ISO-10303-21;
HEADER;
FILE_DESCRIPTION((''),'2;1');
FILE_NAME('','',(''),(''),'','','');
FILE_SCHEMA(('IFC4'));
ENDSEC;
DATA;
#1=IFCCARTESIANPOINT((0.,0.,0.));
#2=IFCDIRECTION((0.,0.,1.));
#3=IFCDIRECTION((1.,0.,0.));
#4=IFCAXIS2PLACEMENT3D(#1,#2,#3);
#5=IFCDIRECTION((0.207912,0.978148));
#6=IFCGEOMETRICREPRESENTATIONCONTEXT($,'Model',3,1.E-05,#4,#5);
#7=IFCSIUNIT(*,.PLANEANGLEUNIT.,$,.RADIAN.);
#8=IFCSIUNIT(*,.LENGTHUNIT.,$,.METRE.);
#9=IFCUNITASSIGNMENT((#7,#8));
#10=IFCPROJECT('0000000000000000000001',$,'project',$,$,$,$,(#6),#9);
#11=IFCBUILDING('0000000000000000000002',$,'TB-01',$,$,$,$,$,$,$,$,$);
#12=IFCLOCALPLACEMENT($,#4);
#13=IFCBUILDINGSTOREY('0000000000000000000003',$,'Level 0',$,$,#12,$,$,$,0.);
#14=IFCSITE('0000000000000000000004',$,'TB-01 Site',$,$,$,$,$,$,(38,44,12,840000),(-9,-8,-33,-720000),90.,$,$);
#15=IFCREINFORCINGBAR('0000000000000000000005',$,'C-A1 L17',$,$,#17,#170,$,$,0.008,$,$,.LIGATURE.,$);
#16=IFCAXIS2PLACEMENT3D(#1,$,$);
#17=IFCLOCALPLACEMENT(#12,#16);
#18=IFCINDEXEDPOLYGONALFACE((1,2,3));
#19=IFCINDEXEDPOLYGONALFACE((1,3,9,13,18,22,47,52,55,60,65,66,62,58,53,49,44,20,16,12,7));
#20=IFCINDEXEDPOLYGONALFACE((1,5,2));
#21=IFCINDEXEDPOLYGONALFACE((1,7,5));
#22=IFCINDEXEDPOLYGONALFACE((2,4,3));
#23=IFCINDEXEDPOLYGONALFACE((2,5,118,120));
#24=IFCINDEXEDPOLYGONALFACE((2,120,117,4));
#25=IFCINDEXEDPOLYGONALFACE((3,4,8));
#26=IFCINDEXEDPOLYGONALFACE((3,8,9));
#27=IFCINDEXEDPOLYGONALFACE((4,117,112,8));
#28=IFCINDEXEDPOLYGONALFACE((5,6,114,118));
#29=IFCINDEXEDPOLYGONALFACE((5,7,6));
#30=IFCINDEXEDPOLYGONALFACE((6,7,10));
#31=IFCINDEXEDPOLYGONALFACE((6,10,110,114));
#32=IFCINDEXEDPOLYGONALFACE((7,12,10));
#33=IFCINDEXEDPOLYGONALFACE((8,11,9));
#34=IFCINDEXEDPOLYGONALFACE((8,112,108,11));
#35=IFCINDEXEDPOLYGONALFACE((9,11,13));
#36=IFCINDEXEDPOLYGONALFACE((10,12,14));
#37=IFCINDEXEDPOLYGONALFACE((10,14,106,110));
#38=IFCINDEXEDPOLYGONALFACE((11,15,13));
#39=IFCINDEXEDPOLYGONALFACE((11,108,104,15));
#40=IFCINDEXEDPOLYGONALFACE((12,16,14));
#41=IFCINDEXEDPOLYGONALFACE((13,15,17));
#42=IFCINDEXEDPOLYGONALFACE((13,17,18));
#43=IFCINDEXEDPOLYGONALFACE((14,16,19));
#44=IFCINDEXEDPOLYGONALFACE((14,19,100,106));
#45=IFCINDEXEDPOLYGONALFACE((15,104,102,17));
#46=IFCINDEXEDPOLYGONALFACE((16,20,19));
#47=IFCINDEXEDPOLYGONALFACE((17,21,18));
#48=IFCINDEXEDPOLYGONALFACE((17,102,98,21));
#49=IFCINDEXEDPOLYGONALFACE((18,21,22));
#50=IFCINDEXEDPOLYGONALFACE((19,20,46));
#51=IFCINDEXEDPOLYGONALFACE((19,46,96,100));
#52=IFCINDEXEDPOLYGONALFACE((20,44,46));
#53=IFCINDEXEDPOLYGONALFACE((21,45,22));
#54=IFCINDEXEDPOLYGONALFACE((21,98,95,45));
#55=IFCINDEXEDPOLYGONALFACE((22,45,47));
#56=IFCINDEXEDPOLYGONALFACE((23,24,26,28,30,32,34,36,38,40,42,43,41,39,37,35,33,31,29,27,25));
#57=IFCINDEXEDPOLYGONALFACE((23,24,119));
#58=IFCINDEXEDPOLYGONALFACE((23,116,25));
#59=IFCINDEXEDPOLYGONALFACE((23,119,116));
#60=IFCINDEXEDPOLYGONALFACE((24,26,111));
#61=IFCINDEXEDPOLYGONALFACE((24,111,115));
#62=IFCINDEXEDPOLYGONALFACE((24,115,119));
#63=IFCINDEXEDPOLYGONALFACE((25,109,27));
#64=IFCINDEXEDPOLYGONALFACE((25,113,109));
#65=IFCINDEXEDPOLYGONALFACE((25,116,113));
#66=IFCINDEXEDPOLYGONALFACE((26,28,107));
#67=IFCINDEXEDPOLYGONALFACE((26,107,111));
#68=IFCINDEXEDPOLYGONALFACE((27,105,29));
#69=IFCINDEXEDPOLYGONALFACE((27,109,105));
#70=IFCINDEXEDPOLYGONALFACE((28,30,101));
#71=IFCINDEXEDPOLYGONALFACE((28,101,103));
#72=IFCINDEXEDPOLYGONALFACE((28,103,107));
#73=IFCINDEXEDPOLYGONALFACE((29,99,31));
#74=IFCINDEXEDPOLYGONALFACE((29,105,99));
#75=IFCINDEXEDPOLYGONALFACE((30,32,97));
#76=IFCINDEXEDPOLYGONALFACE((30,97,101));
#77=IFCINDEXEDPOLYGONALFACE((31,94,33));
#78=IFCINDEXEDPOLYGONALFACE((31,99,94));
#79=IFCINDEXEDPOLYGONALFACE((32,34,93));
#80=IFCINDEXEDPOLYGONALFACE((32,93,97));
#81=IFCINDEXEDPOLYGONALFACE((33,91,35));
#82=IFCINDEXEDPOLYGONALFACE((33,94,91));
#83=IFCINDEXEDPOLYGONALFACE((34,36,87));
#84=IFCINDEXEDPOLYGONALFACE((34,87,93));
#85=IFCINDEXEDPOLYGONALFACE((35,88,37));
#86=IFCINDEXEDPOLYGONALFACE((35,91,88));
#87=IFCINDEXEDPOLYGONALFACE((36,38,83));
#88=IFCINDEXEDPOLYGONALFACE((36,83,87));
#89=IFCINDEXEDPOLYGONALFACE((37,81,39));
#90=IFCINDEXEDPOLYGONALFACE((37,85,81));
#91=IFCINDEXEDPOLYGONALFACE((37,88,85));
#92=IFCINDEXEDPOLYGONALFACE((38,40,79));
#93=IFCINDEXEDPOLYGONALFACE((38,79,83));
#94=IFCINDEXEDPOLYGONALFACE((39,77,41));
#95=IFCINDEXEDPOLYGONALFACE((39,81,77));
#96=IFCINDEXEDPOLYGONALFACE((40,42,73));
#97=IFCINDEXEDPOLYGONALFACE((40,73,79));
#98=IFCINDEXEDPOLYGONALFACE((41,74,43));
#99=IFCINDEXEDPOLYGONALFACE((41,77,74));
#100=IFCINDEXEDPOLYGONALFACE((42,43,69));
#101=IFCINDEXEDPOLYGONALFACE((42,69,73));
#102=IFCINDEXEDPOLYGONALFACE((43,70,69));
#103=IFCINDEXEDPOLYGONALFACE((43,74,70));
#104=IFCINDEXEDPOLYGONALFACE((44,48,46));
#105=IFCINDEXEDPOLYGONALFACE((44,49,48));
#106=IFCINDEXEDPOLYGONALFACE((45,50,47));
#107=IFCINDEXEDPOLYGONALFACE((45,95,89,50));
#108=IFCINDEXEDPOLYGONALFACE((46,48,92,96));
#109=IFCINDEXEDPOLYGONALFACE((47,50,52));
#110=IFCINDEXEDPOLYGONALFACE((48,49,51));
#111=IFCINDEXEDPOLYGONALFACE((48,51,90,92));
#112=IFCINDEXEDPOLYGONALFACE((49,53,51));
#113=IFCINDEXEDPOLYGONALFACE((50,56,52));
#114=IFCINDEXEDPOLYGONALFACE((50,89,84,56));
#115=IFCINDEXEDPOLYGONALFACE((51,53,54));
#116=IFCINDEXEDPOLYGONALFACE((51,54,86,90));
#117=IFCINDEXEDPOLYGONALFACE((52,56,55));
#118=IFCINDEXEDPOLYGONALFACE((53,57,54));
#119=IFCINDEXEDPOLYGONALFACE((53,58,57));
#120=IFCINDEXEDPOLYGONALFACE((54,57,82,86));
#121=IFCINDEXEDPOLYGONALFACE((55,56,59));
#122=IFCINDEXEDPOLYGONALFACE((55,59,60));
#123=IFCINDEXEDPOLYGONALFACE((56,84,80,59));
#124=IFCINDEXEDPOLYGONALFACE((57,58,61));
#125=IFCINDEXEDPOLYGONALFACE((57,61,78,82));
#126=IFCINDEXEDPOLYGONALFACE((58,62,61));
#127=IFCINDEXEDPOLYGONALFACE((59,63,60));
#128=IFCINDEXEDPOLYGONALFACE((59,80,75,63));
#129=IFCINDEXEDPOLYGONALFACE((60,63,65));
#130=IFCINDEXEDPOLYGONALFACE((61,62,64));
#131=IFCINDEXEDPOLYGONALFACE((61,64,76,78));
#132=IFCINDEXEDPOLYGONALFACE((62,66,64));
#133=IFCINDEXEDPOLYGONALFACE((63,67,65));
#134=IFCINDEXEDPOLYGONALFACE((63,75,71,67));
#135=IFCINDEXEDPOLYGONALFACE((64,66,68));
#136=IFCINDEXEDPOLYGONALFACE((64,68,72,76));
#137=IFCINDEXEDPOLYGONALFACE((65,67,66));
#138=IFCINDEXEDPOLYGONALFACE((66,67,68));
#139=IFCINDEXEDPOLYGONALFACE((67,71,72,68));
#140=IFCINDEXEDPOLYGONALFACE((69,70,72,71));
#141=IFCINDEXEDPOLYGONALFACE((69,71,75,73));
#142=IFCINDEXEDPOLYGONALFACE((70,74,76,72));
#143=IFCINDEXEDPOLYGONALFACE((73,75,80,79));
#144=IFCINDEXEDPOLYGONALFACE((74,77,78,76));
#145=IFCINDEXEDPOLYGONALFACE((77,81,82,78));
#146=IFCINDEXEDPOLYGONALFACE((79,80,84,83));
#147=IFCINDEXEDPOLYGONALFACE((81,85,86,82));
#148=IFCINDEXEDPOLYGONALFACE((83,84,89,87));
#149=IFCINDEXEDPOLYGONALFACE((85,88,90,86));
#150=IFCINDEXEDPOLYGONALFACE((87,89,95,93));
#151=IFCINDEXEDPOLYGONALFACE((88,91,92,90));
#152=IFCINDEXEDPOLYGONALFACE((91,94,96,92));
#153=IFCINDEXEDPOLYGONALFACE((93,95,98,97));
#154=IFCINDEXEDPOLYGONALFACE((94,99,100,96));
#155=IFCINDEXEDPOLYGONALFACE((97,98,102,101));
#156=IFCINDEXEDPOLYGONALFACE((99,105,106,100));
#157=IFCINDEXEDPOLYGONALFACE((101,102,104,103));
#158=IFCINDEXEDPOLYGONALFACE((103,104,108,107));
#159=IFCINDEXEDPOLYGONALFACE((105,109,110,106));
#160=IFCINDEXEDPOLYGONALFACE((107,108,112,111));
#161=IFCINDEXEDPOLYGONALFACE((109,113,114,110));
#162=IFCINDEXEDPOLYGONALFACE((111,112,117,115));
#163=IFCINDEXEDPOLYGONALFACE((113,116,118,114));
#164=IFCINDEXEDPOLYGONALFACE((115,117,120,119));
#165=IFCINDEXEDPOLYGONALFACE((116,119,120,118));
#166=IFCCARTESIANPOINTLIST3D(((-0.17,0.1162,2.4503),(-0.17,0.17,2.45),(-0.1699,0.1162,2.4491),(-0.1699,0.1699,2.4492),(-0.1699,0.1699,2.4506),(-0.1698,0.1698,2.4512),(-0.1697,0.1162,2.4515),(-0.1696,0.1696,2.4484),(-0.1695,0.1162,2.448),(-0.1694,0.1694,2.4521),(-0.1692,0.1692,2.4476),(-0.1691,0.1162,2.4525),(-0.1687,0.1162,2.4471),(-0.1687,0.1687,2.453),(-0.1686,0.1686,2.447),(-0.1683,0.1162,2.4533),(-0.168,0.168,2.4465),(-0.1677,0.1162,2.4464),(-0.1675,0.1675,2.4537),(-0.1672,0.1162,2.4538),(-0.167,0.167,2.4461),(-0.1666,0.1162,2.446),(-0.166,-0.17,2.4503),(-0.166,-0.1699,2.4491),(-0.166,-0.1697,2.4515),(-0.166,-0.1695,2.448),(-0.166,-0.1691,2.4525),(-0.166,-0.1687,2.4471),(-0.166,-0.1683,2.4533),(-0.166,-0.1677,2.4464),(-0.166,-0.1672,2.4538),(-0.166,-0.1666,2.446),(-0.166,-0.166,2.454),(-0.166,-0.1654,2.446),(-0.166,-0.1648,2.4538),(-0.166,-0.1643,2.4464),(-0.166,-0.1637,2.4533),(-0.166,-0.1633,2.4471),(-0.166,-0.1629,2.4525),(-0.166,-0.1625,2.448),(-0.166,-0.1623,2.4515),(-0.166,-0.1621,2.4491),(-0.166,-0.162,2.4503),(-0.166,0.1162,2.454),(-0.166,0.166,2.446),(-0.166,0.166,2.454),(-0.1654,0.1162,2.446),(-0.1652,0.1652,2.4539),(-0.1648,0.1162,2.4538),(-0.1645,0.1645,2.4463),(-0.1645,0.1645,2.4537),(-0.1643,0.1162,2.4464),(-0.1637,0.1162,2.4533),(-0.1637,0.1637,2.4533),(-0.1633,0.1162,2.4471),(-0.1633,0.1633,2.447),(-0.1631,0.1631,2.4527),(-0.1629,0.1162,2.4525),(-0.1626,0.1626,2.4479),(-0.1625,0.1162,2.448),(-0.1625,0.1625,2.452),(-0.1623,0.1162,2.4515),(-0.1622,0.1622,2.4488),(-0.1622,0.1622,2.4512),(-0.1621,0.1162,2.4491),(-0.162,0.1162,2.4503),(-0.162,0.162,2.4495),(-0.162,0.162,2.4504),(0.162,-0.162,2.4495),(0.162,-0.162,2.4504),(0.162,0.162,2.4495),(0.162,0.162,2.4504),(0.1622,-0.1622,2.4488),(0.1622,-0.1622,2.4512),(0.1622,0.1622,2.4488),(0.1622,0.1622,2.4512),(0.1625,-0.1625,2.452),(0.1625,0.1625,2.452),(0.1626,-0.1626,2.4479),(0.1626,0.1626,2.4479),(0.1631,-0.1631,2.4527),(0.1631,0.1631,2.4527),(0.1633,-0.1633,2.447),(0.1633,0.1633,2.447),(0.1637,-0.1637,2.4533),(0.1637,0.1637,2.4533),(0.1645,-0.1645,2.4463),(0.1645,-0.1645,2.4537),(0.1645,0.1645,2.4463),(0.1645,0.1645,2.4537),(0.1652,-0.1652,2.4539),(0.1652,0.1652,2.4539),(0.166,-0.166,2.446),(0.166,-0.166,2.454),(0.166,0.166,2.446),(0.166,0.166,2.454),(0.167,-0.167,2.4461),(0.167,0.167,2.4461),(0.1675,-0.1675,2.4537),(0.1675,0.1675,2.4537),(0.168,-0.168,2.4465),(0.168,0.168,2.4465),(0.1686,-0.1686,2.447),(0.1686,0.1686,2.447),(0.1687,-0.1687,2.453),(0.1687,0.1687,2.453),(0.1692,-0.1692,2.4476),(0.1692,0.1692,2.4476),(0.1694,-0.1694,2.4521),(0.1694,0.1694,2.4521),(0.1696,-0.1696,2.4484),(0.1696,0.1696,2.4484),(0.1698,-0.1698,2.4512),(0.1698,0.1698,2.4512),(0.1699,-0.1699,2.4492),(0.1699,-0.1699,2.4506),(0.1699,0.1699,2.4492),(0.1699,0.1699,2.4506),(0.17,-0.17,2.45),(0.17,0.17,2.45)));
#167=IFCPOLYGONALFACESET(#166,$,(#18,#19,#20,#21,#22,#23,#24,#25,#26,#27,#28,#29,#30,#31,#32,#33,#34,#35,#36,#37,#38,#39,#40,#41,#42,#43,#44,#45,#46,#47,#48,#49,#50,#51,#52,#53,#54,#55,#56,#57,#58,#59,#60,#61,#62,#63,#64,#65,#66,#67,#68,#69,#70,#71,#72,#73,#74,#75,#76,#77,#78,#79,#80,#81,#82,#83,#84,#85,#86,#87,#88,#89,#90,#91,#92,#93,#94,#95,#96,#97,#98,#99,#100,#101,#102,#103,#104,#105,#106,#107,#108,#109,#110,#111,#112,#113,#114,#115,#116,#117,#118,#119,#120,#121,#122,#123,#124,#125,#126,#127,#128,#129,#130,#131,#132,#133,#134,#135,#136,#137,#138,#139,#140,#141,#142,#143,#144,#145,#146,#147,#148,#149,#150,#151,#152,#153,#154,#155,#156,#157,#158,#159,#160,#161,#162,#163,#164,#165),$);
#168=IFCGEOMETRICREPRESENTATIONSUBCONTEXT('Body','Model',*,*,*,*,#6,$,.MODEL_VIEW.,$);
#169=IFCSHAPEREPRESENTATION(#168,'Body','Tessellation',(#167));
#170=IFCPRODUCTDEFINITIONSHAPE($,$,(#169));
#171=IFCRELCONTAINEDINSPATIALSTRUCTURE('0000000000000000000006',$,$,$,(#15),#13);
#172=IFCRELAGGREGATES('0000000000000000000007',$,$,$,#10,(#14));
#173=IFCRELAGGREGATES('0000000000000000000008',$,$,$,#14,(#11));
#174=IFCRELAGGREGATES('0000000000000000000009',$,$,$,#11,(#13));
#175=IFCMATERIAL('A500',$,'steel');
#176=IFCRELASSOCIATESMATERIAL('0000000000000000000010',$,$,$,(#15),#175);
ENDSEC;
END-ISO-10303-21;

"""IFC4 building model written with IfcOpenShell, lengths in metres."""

from ifc_helpers import new_model, entity, si_unit, direction, origin_with_axes, place, context, subcontext, project, spatial, material, element, save


model = new_model("IFC4")

# Units and contexts
model_context = context("Model", 3, precision=1e-05, world=origin_with_axes(), true_north=direction((0.207912, 0.978148)))
body_context = subcontext(model_context, "Body", "Model", "MODEL_VIEW")
ifc_project = project(units=[si_unit("PLANEANGLEUNIT", "RADIAN"), si_unit("LENGTHUNIT", "METRE")], contexts=[model_context])

# Site, building, storey
site = spatial("IfcSite", under=ifc_project, Name="TB-01 Site", RefLatitude=(38, 44, 12, 840000), RefLongitude=(-9, -8, -33, -720000), RefElevation=90.0)
building = spatial("IfcBuilding", under=site, Name="TB-01")
storey_placement = place(None, origin_with_axes())
storey = spatial("IfcBuildingStorey", under=building, at=storey_placement, Name="Level 0", Elevation=0.0)

# Reinforcing bar
ifc_material_1 = material(Name="A500", Category="steel")
reinforcing_bar_1_placement = place(storey_placement, origin_with_axes())
element("IfcReinforcingBar", 1, at=reinforcing_bar_1_placement, inside=storey, material=ifc_material_1, Name="C-A1 L17", NominalDiameter=0.008, PredefinedType="LIGATURE", context=body_context, shape_type="AdvancedSweptSolid", body=[
    entity("IfcSweptDiskSolid", entity("IfcPolyline", [entity("IfcCartesianPoint", [-0.166, -0.166, 2.45]), entity("IfcCartesianPoint", [0.166, -0.166, 2.45]), entity("IfcCartesianPoint", [0.166, 0.166, 2.45]), entity("IfcCartesianPoint", [-0.166, 0.166, 2.45]), entity("IfcCartesianPoint", [-0.166, 0.1162, 2.45])]), 0.004),
])

save(model, "model.ifc")
